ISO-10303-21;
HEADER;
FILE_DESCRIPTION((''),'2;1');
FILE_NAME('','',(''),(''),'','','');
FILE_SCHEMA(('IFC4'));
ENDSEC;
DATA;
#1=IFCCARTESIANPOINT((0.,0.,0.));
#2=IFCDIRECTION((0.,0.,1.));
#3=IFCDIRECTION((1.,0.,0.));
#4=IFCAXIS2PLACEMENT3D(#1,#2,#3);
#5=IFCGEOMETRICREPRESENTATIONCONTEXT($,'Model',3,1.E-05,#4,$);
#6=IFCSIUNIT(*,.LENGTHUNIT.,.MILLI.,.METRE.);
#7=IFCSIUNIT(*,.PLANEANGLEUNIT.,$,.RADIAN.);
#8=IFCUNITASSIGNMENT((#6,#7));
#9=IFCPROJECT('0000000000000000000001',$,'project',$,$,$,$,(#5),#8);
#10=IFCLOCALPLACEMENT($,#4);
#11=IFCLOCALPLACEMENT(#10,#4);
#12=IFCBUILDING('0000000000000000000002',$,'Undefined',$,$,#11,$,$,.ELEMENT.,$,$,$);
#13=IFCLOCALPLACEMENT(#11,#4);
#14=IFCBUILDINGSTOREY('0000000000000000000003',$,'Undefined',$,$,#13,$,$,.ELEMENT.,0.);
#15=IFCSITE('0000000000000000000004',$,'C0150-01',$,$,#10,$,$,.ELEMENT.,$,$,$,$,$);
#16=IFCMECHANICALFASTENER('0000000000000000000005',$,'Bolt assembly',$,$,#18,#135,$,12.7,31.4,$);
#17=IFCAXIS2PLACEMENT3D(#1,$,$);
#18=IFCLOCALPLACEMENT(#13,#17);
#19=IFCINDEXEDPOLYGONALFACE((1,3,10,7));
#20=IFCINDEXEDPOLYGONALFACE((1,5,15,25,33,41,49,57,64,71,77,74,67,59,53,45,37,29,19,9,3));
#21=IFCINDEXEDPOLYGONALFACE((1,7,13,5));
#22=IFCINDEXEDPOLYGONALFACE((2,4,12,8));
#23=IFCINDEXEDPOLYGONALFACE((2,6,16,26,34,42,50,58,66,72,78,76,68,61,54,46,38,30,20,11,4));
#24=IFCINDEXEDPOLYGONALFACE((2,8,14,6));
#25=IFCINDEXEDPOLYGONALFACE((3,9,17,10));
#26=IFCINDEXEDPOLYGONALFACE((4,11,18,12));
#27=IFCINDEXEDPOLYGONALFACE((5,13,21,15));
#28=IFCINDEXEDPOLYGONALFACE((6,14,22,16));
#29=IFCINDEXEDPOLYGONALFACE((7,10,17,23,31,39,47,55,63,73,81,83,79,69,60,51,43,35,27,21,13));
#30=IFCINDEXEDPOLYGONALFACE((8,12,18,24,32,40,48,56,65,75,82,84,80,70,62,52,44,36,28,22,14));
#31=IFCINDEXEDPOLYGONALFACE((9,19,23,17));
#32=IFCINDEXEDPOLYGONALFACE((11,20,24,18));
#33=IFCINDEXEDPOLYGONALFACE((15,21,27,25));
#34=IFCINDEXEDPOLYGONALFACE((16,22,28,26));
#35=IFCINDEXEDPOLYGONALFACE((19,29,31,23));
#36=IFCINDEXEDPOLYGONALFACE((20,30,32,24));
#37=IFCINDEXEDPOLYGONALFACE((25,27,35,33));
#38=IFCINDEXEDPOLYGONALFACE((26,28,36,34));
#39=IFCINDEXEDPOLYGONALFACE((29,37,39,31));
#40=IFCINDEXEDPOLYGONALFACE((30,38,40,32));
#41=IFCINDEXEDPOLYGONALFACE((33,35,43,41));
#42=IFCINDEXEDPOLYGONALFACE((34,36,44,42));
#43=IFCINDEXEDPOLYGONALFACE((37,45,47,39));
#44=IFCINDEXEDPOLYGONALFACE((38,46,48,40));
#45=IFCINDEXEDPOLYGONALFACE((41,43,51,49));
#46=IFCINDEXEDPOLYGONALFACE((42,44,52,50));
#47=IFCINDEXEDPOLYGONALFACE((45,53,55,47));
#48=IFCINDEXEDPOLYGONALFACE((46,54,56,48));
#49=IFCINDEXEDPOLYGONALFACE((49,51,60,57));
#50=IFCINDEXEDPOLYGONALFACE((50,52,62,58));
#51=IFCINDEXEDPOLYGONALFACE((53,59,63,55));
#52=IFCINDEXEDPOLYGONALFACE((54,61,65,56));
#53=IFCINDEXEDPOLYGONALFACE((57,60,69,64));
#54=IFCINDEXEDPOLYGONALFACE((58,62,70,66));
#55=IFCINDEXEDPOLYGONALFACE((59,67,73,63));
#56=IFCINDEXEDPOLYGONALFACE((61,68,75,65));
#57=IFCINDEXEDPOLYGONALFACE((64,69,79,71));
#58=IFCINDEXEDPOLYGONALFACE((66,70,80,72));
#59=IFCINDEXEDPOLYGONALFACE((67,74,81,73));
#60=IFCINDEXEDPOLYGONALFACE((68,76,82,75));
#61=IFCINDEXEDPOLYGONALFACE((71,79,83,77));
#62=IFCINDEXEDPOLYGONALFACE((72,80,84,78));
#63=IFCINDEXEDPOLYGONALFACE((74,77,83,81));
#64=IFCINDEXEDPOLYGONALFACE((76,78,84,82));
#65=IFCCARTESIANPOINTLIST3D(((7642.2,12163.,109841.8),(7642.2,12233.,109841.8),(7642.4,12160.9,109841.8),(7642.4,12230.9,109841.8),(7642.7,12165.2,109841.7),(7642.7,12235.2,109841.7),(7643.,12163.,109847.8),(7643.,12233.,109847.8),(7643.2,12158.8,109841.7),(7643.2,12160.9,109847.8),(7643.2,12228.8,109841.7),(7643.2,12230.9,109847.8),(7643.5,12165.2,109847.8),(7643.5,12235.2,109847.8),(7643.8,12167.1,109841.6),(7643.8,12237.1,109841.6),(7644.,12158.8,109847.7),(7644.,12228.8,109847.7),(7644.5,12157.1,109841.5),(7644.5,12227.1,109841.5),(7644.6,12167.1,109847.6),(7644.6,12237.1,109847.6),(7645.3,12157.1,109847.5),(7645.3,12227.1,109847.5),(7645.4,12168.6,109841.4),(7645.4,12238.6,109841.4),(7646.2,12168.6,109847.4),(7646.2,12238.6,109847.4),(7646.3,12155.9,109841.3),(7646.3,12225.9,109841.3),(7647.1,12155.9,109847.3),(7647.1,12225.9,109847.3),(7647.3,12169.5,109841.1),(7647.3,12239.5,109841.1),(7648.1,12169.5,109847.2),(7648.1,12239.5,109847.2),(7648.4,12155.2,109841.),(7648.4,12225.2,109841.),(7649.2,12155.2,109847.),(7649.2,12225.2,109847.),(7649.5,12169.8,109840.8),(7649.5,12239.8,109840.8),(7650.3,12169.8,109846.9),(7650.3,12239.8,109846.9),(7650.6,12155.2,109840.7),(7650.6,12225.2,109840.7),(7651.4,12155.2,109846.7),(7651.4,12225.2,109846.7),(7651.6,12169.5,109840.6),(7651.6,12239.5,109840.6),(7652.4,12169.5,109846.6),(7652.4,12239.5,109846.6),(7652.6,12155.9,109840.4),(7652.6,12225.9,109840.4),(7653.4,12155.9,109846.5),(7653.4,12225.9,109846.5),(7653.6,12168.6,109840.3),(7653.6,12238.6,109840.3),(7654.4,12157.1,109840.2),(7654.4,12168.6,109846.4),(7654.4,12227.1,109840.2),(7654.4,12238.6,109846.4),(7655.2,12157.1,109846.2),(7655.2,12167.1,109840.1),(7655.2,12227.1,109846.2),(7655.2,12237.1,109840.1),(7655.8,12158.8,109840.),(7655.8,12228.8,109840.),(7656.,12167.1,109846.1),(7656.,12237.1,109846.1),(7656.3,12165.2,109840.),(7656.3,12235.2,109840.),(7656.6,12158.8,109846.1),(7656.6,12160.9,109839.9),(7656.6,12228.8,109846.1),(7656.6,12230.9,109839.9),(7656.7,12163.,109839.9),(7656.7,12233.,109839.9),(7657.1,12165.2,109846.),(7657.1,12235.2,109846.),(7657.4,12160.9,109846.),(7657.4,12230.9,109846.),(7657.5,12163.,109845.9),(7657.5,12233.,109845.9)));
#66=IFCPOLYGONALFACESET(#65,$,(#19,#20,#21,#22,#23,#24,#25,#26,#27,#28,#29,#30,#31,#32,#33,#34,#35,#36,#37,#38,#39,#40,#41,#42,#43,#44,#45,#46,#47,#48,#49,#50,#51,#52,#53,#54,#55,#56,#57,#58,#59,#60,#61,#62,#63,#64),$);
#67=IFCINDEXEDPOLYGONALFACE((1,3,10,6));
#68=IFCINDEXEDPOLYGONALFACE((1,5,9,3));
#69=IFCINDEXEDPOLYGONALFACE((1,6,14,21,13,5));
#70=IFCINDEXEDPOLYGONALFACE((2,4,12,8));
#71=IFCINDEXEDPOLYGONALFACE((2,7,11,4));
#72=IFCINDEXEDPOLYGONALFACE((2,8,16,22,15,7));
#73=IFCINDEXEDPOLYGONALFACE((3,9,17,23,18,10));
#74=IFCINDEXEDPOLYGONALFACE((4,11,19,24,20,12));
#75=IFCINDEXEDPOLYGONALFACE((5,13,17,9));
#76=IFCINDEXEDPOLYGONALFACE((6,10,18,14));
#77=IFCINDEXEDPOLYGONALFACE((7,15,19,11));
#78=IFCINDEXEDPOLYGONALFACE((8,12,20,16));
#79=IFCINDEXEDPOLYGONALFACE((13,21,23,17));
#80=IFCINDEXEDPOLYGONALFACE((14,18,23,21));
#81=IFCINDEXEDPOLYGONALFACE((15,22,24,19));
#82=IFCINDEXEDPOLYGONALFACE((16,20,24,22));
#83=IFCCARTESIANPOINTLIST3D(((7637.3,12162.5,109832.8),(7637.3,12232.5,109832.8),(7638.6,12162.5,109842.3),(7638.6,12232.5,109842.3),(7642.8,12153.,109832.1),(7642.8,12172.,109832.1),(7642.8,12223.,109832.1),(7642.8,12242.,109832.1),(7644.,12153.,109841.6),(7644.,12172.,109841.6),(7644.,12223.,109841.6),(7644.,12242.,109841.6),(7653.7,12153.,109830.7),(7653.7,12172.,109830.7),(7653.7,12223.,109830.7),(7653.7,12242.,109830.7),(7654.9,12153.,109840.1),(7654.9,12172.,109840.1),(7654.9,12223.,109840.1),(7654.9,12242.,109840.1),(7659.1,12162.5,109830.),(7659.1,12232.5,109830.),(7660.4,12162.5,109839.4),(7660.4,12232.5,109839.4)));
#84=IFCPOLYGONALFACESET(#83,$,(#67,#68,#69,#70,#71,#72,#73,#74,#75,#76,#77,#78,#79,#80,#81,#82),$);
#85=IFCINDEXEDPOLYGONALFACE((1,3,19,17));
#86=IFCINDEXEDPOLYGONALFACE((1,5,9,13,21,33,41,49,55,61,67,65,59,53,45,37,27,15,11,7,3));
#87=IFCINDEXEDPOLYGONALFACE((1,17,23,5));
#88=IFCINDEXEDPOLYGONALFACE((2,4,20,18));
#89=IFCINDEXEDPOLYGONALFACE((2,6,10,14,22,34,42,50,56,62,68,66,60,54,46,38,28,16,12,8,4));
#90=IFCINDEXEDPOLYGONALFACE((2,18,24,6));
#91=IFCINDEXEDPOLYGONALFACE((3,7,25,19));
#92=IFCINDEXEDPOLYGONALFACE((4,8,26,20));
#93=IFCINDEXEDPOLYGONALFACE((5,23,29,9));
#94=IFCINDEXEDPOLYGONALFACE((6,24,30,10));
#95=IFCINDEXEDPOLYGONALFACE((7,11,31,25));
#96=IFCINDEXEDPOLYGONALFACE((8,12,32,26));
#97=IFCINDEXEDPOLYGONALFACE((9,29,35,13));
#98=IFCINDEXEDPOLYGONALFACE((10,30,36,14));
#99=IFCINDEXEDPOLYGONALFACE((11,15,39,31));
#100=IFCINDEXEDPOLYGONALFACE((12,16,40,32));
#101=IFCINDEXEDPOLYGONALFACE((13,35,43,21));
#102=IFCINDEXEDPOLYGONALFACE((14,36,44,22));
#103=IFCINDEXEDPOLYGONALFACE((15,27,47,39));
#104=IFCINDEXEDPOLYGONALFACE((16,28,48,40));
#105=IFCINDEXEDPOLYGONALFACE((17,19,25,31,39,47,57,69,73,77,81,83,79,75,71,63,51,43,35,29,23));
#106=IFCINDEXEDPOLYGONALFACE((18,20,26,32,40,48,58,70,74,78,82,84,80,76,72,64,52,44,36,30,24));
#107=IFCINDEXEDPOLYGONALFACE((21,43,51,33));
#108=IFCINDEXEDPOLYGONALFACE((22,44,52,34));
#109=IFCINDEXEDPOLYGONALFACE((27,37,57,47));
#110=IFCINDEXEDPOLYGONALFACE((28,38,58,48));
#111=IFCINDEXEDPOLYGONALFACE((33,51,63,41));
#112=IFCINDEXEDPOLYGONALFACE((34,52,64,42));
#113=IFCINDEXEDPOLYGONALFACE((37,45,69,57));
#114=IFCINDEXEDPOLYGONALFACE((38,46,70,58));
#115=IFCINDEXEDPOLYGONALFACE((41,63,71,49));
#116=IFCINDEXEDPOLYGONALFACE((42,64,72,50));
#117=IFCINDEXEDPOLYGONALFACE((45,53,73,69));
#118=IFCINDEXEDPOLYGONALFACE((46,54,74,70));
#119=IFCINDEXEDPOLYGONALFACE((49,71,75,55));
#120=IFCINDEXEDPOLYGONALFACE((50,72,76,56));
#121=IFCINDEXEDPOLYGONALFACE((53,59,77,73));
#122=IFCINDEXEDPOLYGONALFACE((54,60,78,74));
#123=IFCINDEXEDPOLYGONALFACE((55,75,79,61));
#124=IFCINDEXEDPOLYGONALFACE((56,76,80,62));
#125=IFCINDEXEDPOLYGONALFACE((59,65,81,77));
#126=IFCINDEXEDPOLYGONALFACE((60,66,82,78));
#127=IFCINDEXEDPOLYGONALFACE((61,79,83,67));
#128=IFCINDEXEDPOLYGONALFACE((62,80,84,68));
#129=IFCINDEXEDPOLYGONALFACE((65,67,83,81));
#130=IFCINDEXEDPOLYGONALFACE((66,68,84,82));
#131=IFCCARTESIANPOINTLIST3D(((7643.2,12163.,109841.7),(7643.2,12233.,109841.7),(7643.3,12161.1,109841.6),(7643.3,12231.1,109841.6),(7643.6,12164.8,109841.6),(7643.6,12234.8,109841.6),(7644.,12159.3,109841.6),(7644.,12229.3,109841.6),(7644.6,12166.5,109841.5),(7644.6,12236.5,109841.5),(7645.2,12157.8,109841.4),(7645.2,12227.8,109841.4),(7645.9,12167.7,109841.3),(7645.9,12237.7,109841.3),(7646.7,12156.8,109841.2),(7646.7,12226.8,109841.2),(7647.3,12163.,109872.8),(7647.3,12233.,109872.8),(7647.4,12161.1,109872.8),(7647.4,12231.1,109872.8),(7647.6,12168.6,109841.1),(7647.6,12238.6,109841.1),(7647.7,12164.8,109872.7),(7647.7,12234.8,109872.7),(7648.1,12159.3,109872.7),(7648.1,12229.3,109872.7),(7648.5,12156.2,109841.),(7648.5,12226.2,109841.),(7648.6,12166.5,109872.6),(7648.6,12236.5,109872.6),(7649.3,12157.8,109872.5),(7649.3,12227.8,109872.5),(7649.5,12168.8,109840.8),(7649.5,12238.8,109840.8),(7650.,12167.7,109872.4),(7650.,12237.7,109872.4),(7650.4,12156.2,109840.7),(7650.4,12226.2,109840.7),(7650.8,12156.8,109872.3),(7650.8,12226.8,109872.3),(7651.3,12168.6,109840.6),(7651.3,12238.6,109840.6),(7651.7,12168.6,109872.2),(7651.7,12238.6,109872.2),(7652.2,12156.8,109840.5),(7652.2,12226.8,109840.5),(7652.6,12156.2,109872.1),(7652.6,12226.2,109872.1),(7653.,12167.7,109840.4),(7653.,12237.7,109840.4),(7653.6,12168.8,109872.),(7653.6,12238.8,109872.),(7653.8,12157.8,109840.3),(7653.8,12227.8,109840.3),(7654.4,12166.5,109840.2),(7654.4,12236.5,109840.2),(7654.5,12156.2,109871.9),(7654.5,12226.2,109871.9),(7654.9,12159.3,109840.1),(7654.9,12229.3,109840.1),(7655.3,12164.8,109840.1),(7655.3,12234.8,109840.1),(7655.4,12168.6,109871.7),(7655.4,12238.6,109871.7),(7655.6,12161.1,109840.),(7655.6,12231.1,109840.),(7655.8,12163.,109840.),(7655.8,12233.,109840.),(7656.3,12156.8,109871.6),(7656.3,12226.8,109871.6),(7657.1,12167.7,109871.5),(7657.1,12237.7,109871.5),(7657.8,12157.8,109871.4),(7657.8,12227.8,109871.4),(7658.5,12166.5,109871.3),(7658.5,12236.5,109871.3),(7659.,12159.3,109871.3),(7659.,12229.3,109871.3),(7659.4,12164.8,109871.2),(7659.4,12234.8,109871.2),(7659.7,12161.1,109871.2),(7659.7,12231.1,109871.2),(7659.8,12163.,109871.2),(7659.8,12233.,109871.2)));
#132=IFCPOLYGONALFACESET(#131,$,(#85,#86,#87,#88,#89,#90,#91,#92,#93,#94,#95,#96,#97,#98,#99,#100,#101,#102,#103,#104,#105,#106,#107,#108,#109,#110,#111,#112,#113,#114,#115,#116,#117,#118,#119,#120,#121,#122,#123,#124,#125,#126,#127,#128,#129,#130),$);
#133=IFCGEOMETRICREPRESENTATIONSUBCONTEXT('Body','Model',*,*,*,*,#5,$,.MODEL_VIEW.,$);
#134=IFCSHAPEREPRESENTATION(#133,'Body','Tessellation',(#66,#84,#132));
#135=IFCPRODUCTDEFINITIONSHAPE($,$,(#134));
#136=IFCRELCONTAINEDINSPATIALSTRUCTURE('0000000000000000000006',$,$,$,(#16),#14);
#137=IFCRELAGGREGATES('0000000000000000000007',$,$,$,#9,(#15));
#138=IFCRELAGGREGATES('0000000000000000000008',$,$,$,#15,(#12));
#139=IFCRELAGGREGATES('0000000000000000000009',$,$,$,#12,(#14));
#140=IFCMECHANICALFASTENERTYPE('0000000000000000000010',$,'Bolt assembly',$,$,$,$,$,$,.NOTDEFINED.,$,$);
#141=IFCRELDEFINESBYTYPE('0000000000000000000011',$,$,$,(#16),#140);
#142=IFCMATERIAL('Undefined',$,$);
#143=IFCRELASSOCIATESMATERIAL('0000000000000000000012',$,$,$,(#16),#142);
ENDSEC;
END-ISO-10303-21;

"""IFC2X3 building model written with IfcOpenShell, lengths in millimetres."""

from ifc_helpers import new_model, si_unit, frame, origin_with_axes, origin_2d_with_axis, place, context, subcontext, project, spatial, polyline, circle, outline, extrude, source, transform, mapped, material, type_object, element, save


model = new_model("IFC2X3")

# Units and contexts
model_context = context("Model", 3, precision=1e-05, world=origin_with_axes())
body_context = subcontext(model_context, "Body", "Model", "MODEL_VIEW")
ifc_project = project(units=[si_unit("LENGTHUNIT", "METRE", prefix="MILLI"), si_unit("PLANEANGLEUNIT", "RADIAN")], contexts=[model_context])

# Site, building, storey
site_placement = place(None, origin_with_axes())
site = spatial("IfcSite", under=ifc_project, at=site_placement, Name="C0150-01", CompositionType="ELEMENT")
building_placement = place(site_placement, origin_with_axes())
building = spatial("IfcBuilding", under=site, at=building_placement, Name="Undefined", CompositionType="ELEMENT")
storey_placement = place(building_placement, origin_with_axes())
storey = spatial("IfcBuildingStorey", under=building, at=storey_placement, Name="Undefined", CompositionType="ELEMENT", Elevation=0.0)

# Mechanical fastener
ifc_material_1 = material(Name="Undefined")
mechanical_fastener_type = type_object("IfcMechanicalFastenerType", Name="Bolt assembly")
shared_shape_1 = source(origin_with_axes(), body_context, "Body", "SweptSolid", [
    extrude(circle(Radius=7.3, at=origin_2d_with_axis()), frame((0.0, -2.0, 0.0), z_axis=(0.0, 1.0, 0.0), x_axis=(1.0, 0.0, 0.0)), (0.0, 0.0, 1.0), 6.1),
    extrude(outline(polyline([(9.5, -5.5), (9.5, 5.5), (0.0, 11.0), (-9.5, 5.5), (-9.5, -5.5), (0.0, -11.0), (9.5, -5.5)])), frame((0.0, -11.5, 0.0), z_axis=(0.0, 1.0, 0.0), x_axis=(1.0, 0.0, 0.0)), (0.0, 0.0, 1.0), 9.5),
    extrude(circle(Radius=6.3, at=origin_2d_with_axis()), frame((0.0, -2.0, 0.0), z_axis=(0.0, 1.0, 0.0), x_axis=(1.0, 0.0, 0.0)), (0.0, 0.0, 1.0), 31.4),
])
for number, where, z_axis, x_axis, name in (
    (1, (7649.7, 12162.5, 109842.8), (0.991507, 0.0, -0.130054), (0.0, 1.0, 0.0), "Bolt assembly"),
):
    element("IfcMechanicalFastener", number, at=place(storey_placement, frame(where, z_axis=z_axis, x_axis=x_axis)), inside=storey, type_object=mechanical_fastener_type, material=ifc_material_1, Name=name, NominalDiameter=12.7, NominalLength=31.4, context=body_context, shape_type="MappedRepresentation", body=[
        mapped(shared_shape_1, transform((0.0, 0.0, 0.0))),
        mapped(shared_shape_1, transform((70.0, 0.0, 0.0))),
    ])

save(model, "model.ifc")
